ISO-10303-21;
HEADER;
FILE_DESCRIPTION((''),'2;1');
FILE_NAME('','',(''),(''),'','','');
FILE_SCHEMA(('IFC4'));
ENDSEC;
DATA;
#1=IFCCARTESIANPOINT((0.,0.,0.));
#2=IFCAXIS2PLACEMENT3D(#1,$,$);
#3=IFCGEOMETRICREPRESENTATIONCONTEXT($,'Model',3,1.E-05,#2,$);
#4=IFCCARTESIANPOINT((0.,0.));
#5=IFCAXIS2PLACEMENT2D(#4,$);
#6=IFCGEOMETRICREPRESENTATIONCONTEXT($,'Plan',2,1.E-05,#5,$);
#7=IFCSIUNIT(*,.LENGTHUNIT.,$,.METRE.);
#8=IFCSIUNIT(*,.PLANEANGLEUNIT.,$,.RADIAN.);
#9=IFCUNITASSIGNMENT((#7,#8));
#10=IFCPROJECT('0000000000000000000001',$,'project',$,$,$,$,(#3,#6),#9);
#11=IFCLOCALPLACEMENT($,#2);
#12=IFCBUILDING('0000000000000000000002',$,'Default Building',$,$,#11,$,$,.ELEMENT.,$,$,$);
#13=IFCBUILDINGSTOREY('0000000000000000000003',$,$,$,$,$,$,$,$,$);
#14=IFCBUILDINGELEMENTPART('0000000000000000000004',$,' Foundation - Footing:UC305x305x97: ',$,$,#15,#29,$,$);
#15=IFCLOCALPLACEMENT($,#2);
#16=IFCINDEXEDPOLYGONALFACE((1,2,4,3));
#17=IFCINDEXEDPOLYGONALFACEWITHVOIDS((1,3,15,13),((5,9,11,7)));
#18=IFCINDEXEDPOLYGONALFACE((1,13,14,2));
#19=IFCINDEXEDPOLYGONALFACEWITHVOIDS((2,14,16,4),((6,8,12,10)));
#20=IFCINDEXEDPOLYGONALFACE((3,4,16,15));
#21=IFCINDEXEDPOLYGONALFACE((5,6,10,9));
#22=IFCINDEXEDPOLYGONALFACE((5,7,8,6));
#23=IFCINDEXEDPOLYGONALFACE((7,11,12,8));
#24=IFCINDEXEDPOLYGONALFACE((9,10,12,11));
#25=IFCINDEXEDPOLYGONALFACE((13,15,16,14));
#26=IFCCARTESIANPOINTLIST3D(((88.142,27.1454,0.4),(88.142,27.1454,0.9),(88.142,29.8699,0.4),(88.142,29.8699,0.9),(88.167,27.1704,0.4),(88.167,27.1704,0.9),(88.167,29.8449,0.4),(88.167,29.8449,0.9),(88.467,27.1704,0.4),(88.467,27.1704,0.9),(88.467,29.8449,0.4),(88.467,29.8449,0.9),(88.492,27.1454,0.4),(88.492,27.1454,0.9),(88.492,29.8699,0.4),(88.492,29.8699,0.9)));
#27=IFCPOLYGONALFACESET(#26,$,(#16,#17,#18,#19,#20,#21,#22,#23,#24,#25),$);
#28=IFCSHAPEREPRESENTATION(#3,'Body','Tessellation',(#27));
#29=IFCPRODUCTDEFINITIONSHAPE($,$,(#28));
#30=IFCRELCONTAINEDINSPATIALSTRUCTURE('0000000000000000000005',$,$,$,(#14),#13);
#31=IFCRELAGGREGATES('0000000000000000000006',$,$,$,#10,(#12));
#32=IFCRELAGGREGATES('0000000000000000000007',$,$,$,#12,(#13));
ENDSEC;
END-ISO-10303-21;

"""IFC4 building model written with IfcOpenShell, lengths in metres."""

from ifc_helpers import new_model, si_unit, origin, origin_2d, place, context, project, spatial, polyline, outline, extrude, element, save


model = new_model("IFC4")

# Units and contexts
model_context = context("Model", 3, precision=1e-05, world=origin())
plan_context = context("Plan", 2, precision=1e-05, world=origin_2d())
ifc_project = project(units=[si_unit("LENGTHUNIT", "METRE"), si_unit("PLANEANGLEUNIT", "RADIAN")], contexts=[model_context, plan_context])

# Building, storey
building_placement = place(None, origin())
building = spatial("IfcBuilding", under=ifc_project, at=building_placement, Name="Default Building", CompositionType="ELEMENT")
storey = spatial("IfcBuildingStorey", under=building)

# Building element part, opening
building_element_part_1 = element("IfcBuildingElementPart", 1, inside=storey, Name=" Foundation - Footing:UC305x305x97: ", context=model_context, shape_type="SweptSolid", body=[
    extrude(outline(polyline([(88.492, 27.1454, 0.4), (88.142, 27.1454, 0.4), (88.142, 29.8699, 0.4), (88.492, 29.8699, 0.4), (88.492, 27.1454, 0.4)])), None, (0.0, 0.0, 1.0), 0.5),
])
element("IfcOpeningElement", 2, inside=storey, cuts=building_element_part_1, context=model_context, shape_type="SweptSolid", body=[
    extrude(outline(polyline([(88.467, 27.1704, 0.4), (88.167, 27.1704, 0.4), (88.167, 29.8449, 0.4), (88.467, 29.8449, 0.4), (88.467, 27.1704, 0.4)])), None, (0.0, 0.0, 1.0), 0.5),
])

save(model, "model.ifc")
